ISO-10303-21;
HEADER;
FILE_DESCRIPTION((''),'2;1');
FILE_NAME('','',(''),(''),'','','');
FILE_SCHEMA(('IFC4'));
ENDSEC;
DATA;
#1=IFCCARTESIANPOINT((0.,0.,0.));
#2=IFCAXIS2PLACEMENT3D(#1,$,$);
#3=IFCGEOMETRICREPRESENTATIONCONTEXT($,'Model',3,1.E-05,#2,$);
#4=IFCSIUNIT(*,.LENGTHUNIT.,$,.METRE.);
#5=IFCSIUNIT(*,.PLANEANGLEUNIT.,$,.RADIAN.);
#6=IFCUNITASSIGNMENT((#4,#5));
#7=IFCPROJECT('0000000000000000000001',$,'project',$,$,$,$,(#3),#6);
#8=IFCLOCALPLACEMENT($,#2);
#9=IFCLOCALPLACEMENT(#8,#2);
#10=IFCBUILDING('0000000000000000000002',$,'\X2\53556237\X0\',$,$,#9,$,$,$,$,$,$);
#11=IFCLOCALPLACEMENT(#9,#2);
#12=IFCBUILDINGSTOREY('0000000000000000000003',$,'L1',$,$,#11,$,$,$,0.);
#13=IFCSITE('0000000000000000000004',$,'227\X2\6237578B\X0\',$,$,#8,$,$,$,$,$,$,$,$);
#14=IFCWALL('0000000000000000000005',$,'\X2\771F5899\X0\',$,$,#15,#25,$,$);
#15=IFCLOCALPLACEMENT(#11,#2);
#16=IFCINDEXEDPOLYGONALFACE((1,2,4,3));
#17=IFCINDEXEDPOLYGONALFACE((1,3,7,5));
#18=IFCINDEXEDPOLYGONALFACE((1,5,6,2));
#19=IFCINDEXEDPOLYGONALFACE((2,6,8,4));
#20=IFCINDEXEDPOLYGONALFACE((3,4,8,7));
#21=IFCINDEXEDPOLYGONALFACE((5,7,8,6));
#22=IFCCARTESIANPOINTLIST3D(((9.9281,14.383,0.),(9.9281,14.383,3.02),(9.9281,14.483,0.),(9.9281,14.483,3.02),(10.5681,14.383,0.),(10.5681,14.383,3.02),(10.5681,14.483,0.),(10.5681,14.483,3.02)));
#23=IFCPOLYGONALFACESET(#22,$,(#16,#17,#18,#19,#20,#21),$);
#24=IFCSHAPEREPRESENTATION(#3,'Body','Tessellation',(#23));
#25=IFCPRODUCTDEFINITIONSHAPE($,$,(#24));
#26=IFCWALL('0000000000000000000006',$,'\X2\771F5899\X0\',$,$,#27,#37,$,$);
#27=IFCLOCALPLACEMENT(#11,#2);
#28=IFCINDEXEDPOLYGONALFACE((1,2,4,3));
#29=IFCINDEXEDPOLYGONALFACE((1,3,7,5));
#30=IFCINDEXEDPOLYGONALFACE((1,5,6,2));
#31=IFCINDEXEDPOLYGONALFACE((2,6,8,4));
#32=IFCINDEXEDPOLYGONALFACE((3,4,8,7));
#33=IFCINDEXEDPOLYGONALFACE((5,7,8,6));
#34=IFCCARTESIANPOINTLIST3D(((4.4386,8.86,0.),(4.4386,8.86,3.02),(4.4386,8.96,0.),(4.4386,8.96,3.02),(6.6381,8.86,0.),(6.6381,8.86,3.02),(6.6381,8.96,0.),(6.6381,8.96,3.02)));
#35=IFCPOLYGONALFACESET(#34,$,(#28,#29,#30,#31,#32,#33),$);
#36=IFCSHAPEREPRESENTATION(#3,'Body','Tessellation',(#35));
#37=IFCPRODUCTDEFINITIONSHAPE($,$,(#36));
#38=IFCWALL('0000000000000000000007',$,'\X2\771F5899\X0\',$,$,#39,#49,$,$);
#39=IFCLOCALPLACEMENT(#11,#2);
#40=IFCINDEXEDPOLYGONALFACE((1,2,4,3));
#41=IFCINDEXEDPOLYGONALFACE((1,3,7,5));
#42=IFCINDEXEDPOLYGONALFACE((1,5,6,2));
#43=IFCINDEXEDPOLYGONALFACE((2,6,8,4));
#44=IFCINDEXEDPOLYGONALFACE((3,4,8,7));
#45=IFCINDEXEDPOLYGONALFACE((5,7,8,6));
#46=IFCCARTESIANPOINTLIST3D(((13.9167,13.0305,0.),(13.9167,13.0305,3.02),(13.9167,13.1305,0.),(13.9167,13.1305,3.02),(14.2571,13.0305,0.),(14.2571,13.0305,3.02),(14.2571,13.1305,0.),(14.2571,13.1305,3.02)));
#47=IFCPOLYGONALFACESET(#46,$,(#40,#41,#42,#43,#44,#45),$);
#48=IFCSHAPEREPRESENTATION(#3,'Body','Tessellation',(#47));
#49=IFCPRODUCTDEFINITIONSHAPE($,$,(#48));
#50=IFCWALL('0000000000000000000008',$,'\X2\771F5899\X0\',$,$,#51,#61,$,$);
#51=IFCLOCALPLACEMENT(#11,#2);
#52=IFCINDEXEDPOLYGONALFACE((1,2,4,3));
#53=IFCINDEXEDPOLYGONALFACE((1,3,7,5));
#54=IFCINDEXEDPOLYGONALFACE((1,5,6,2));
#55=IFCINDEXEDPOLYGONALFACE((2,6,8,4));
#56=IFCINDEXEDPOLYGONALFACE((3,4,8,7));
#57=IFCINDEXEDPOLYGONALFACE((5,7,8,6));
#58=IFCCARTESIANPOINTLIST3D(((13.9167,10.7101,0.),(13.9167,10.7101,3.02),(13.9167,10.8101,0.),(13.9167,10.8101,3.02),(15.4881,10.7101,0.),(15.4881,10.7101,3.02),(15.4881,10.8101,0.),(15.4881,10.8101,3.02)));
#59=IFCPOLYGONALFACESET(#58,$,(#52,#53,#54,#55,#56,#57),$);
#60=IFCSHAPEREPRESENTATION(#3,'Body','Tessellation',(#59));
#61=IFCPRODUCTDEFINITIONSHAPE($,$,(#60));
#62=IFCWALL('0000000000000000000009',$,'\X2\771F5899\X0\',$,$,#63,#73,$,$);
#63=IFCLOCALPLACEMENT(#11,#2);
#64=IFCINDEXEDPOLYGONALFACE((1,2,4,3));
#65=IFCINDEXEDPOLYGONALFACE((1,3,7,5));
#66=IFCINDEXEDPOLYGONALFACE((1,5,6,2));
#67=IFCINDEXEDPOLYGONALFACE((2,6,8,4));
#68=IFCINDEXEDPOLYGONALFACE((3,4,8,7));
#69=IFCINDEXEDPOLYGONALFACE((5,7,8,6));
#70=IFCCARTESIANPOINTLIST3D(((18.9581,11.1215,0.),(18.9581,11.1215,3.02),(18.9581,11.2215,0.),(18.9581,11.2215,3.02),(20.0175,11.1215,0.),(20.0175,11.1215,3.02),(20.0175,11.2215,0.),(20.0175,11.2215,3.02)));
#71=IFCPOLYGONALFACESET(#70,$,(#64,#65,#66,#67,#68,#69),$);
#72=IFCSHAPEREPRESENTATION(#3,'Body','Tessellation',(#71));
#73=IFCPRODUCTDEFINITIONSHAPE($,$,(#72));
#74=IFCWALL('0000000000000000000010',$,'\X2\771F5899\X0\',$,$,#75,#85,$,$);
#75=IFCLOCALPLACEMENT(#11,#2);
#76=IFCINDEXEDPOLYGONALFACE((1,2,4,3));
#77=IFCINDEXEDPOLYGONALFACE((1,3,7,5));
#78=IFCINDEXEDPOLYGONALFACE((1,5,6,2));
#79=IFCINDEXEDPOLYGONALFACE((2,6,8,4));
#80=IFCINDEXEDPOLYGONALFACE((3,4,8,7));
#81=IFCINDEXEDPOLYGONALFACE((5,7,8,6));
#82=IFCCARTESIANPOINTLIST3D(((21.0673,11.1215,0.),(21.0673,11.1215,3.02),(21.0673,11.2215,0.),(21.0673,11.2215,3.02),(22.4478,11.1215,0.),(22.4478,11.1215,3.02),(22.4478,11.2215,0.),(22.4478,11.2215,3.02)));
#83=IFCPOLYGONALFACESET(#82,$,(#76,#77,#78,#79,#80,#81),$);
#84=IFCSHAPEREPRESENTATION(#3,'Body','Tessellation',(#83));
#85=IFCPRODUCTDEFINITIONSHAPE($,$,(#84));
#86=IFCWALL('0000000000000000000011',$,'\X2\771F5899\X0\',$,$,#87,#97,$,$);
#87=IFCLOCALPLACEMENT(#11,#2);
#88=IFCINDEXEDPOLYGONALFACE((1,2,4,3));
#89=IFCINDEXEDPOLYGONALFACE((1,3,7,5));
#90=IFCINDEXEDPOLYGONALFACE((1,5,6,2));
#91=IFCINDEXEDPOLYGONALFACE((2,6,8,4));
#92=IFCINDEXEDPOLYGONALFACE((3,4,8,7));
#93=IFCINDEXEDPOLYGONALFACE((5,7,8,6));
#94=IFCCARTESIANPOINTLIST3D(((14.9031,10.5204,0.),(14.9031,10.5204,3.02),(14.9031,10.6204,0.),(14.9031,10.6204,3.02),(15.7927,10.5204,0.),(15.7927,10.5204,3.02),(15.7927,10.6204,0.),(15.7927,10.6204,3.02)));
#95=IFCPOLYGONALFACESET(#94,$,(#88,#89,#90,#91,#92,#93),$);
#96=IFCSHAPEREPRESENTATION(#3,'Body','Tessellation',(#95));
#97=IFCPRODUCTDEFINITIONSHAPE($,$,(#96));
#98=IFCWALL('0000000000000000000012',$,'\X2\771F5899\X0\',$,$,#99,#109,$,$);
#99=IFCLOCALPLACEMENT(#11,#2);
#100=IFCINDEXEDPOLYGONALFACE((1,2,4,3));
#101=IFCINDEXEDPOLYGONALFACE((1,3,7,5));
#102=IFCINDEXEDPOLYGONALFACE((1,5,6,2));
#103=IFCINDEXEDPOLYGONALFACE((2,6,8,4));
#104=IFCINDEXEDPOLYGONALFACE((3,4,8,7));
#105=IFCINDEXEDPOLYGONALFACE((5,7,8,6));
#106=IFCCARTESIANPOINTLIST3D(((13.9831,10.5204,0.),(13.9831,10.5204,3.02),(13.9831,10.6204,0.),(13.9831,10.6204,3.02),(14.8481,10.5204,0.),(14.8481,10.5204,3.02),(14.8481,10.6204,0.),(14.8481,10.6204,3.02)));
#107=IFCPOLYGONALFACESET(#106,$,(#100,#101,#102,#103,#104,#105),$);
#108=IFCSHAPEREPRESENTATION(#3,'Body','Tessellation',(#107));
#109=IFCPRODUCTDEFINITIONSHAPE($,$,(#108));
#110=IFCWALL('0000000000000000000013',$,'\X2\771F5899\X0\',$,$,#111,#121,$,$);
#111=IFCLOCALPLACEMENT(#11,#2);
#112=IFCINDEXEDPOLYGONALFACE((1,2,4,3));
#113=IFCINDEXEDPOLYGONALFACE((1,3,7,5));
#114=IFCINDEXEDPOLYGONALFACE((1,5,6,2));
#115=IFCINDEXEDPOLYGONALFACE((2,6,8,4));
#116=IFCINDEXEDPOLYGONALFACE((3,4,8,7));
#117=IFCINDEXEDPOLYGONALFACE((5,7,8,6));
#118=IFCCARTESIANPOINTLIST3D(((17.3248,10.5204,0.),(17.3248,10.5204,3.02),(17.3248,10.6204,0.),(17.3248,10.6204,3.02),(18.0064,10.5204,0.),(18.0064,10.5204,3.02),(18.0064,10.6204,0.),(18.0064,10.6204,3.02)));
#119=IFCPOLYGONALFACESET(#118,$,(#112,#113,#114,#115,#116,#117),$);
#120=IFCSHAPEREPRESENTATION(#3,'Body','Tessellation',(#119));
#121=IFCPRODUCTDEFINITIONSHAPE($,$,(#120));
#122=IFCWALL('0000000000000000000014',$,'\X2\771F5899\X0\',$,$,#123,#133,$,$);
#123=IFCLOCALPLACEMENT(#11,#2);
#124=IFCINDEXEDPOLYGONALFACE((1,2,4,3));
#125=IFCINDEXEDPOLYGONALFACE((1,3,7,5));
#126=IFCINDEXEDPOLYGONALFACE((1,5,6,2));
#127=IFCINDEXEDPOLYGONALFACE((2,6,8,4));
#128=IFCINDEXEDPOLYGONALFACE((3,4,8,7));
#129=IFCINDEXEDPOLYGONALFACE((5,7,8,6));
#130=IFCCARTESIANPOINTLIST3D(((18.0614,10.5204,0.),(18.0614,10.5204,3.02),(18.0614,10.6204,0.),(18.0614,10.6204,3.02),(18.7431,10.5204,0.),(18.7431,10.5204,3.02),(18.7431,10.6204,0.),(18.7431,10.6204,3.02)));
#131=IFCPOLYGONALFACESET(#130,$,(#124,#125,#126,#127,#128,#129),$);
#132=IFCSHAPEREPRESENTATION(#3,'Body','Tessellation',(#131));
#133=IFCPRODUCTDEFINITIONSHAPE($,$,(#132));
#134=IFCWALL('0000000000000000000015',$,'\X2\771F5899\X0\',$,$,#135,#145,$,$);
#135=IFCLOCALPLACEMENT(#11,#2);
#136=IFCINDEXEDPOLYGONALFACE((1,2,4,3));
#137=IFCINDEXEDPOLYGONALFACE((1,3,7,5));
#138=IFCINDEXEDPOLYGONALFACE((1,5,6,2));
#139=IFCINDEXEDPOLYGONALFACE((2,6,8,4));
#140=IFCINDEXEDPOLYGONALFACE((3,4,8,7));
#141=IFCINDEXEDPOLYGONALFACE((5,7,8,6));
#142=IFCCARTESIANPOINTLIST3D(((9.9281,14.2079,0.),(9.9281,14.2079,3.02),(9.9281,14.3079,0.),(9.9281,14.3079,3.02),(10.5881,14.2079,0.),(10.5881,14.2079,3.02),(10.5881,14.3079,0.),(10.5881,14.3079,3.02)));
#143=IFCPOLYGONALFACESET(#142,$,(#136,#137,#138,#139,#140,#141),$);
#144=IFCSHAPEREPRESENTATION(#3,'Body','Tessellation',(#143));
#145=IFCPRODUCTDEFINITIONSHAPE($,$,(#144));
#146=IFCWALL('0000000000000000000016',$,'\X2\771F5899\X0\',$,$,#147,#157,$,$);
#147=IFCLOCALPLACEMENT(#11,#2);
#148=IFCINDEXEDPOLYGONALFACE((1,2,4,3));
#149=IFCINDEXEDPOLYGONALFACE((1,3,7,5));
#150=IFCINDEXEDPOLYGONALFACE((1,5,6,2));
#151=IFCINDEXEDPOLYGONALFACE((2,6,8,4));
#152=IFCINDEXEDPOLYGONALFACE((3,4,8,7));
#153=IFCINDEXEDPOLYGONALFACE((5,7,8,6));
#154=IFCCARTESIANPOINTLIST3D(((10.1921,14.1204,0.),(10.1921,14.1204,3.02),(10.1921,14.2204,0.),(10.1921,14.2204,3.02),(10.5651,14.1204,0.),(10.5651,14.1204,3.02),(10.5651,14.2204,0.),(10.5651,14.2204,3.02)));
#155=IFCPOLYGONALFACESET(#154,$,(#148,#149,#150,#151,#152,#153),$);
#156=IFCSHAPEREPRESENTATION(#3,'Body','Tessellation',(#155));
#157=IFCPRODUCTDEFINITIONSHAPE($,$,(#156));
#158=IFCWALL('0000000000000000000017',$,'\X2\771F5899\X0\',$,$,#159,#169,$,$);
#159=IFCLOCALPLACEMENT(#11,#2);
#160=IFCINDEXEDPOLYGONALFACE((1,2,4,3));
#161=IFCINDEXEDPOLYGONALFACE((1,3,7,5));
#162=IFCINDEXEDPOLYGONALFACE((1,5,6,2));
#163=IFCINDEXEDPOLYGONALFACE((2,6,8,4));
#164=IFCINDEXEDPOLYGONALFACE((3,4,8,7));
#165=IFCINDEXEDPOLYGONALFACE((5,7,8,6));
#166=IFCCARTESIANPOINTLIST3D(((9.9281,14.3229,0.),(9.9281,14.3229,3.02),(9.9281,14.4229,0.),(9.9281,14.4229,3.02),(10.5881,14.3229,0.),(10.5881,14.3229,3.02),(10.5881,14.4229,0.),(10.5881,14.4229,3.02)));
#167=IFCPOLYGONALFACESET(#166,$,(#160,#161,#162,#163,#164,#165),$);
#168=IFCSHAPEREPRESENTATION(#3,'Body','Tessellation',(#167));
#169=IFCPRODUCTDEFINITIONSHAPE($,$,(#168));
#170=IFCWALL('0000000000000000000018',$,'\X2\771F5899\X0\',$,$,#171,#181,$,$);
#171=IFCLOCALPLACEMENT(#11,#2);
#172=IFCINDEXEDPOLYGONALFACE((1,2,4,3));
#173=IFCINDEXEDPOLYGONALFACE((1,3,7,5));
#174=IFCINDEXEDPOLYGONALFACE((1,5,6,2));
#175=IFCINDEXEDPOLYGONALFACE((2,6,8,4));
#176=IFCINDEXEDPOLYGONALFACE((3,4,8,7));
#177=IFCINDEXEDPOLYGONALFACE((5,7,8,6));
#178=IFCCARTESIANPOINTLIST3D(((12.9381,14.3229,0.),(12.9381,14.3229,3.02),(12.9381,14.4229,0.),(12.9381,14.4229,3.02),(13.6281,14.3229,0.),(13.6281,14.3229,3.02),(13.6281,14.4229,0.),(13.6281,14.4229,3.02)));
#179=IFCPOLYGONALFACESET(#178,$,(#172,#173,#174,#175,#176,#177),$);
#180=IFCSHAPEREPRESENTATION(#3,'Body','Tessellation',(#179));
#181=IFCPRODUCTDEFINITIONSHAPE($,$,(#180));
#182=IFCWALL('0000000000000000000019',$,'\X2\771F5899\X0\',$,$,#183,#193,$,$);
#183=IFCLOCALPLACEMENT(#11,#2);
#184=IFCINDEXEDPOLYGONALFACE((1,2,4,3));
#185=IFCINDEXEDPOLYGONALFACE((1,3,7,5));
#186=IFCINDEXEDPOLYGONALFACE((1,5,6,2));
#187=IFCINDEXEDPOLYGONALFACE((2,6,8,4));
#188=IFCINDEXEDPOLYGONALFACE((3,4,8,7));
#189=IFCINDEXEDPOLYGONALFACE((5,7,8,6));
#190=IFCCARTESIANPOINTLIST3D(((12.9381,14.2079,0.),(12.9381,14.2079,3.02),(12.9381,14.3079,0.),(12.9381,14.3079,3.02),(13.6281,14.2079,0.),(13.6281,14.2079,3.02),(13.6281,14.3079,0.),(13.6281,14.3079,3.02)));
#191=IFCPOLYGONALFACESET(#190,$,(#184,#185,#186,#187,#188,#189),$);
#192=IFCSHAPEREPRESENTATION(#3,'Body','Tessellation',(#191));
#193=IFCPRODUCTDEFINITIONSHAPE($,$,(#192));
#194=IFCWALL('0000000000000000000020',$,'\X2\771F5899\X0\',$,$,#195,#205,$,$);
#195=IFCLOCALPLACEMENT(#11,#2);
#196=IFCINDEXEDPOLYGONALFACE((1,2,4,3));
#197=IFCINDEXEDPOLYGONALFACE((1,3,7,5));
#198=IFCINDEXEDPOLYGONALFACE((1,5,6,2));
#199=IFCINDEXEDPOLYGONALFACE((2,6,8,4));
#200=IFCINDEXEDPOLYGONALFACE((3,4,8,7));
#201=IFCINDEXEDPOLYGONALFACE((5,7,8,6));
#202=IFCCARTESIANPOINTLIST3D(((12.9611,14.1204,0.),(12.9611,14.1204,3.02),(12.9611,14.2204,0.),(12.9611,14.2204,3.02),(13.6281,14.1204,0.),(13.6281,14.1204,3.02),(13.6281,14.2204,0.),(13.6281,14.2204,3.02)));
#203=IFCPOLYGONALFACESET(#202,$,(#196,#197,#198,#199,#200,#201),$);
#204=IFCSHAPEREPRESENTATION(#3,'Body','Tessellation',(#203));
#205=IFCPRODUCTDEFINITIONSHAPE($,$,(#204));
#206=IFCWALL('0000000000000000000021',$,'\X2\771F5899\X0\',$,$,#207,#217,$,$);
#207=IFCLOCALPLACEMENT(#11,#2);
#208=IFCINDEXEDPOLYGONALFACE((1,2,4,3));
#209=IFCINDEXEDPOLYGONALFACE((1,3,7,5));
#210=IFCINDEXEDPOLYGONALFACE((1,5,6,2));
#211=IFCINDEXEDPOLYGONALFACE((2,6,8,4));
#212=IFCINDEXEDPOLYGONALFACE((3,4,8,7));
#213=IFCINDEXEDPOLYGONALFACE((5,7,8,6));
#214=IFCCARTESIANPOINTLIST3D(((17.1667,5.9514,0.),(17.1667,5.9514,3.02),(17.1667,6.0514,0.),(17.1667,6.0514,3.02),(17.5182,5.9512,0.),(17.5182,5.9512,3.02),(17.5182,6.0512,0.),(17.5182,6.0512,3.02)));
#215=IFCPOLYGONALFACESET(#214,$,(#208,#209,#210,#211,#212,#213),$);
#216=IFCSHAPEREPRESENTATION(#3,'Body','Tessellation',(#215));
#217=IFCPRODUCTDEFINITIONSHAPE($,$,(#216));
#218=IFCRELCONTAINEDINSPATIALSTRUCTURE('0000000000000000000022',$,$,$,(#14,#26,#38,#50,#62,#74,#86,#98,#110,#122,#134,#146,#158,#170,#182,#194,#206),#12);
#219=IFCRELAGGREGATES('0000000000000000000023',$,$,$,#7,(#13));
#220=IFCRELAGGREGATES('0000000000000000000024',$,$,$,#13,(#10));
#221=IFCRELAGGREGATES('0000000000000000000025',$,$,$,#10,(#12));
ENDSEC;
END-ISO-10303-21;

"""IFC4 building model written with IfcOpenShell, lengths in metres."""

from ifc_helpers import new_model, si_unit, origin, place, context, project, spatial, polyline, outline, extrude, element, save


model = new_model("IFC4")

# Units and contexts
model_context = context("Model", 3, precision=1e-05, world=origin())
ifc_project = project(units=[si_unit("LENGTHUNIT", "METRE"), si_unit("PLANEANGLEUNIT", "RADIAN")], contexts=[model_context])

# Site, building, storey
site_placement = place(None, origin())
site = spatial("IfcSite", under=ifc_project, at=site_placement, Name="227户型")
building_placement = place(site_placement, origin())
building = spatial("IfcBuilding", under=site, at=building_placement, Name="单户")
storey_placement = place(building_placement, origin())
storey = spatial("IfcBuildingStorey", under=building, at=storey_placement, Name="L1", Elevation=0.0)

# Walls
wall_1_placement = place(storey_placement, origin())
element("IfcWall", 1, at=wall_1_placement, inside=storey, Name="真墙", context=model_context, shape_type="SweptSolid", body=[
    extrude(outline(polyline([(10.5681, 14.383), (9.9281, 14.383), (9.9281, 14.483), (10.5681, 14.483), (10.5681, 14.383)])), origin(), (0.0, 0.0, 1.0), 3.02),
])
wall_2_placement = place(storey_placement, origin())
element("IfcWall", 2, at=wall_2_placement, inside=storey, Name="真墙", context=model_context, shape_type="SweptSolid", body=[
    extrude(outline(polyline([(6.6381, 8.86), (4.4386, 8.86), (4.4386, 8.96), (6.6381, 8.96), (6.6381, 8.86)])), origin(), (0.0, 0.0, 1.0), 3.02),
])
wall_3_placement = place(storey_placement, origin())
element("IfcWall", 3, at=wall_3_placement, inside=storey, Name="真墙", context=model_context, shape_type="SweptSolid", body=[
    extrude(outline(polyline([(14.2571, 13.0305), (13.9167, 13.0305), (13.9167, 13.1305), (14.2571, 13.1305), (14.2571, 13.0305)])), origin(), (0.0, 0.0, 1.0), 3.02),
])
wall_4_placement = place(storey_placement, origin())
element("IfcWall", 4, at=wall_4_placement, inside=storey, Name="真墙", context=model_context, shape_type="SweptSolid", body=[
    extrude(outline(polyline([(13.9167, 10.8101), (15.4881, 10.8101), (15.4881, 10.7101), (13.9167, 10.7101), (13.9167, 10.8101)])), origin(), (0.0, 0.0, 1.0), 3.02),
])
wall_5_placement = place(storey_placement, origin())
element("IfcWall", 5, at=wall_5_placement, inside=storey, Name="真墙", context=model_context, shape_type="SweptSolid", body=[
    extrude(outline(polyline([(20.0175, 11.1215), (18.9581, 11.1215), (18.9581, 11.2215), (20.0175, 11.2215), (20.0175, 11.1215)])), origin(), (0.0, 0.0, 1.0), 3.02),
])
wall_6_placement = place(storey_placement, origin())
element("IfcWall", 6, at=wall_6_placement, inside=storey, Name="真墙", context=model_context, shape_type="SweptSolid", body=[
    extrude(outline(polyline([(21.0673, 11.2215), (22.4478, 11.2215), (22.4478, 11.1215), (21.0673, 11.1215), (21.0673, 11.2215)])), origin(), (0.0, 0.0, 1.0), 3.02),
])

# Walls
wall_7_placement = place(storey_placement, origin())
element("IfcWall", 7, at=wall_7_placement, inside=storey, Name="真墙", context=model_context, shape_type="SweptSolid", body=[
    extrude(outline(polyline([(14.9031, 10.6204), (15.7927, 10.6204), (15.7927, 10.5204), (14.9031, 10.5204), (14.9031, 10.6204)])), origin(), (0.0, 0.0, 1.0), 3.02),
])
wall_8_placement = place(storey_placement, origin())
element("IfcWall", 8, at=wall_8_placement, inside=storey, Name="真墙", context=model_context, shape_type="SweptSolid", body=[
    extrude(outline(polyline([(13.9831, 10.6204), (14.8481, 10.6204), (14.8481, 10.5204), (13.9831, 10.5204), (13.9831, 10.6204)])), origin(), (0.0, 0.0, 1.0), 3.02),
])
wall_9_placement = place(storey_placement, origin())
element("IfcWall", 9, at=wall_9_placement, inside=storey, Name="真墙", context=model_context, shape_type="SweptSolid", body=[
    extrude(outline(polyline([(18.0064, 10.5204), (17.3248, 10.5204), (17.3248, 10.6204), (18.0064, 10.6204), (18.0064, 10.5204)])), origin(), (0.0, 0.0, 1.0), 3.02),
])
wall_10_placement = place(storey_placement, origin())
element("IfcWall", 10, at=wall_10_placement, inside=storey, Name="真墙", context=model_context, shape_type="SweptSolid", body=[
    extrude(outline(polyline([(18.7431, 10.5204), (18.0614, 10.5204), (18.0614, 10.6204), (18.7431, 10.6204), (18.7431, 10.5204)])), origin(), (0.0, 0.0, 1.0), 3.02),
])
wall_11_placement = place(storey_placement, origin())
element("IfcWall", 11, at=wall_11_placement, inside=storey, Name="真墙", context=model_context, shape_type="SweptSolid", body=[
    extrude(outline(polyline([(10.5881, 14.2079), (9.9281, 14.2079), (9.9281, 14.3079), (10.5881, 14.3079), (10.5881, 14.2079)])), origin(), (0.0, 0.0, 1.0), 3.02),
])
wall_12_placement = place(storey_placement, origin())
element("IfcWall", 12, at=wall_12_placement, inside=storey, Name="真墙", context=model_context, shape_type="SweptSolid", body=[
    extrude(outline(polyline([(10.5651, 14.1204), (10.1921, 14.1204), (10.1921, 14.2204), (10.5651, 14.2204), (10.5651, 14.1204)])), origin(), (0.0, 0.0, 1.0), 3.02),
])
wall_13_placement = place(storey_placement, origin())
element("IfcWall", 13, at=wall_13_placement, inside=storey, Name="真墙", context=model_context, shape_type="SweptSolid", body=[
    extrude(outline(polyline([(10.5881, 14.3229), (9.9281, 14.3229), (9.9281, 14.4229), (10.5881, 14.4229), (10.5881, 14.3229)])), origin(), (0.0, 0.0, 1.0), 3.02),
])

# Walls
wall_14_placement = place(storey_placement, origin())
element("IfcWall", 14, at=wall_14_placement, inside=storey, Name="真墙", context=model_context, shape_type="SweptSolid", body=[
    extrude(outline(polyline([(12.9381, 14.4229), (13.6281, 14.4229), (13.6281, 14.3229), (12.9381, 14.3229), (12.9381, 14.4229)])), origin(), (0.0, 0.0, 1.0), 3.02),
])
wall_15_placement = place(storey_placement, origin())
element("IfcWall", 15, at=wall_15_placement, inside=storey, Name="真墙", context=model_context, shape_type="SweptSolid", body=[
    extrude(outline(polyline([(12.9381, 14.3079), (13.6281, 14.3079), (13.6281, 14.2079), (12.9381, 14.2079), (12.9381, 14.3079)])), origin(), (0.0, 0.0, 1.0), 3.02),
])
wall_16_placement = place(storey_placement, origin())
element("IfcWall", 16, at=wall_16_placement, inside=storey, Name="真墙", context=model_context, shape_type="SweptSolid", body=[
    extrude(outline(polyline([(12.9611, 14.2204), (13.6281, 14.2204), (13.6281, 14.1204), (12.9611, 14.1204), (12.9611, 14.2204)])), origin(), (0.0, 0.0, 1.0), 3.02),
])

# Wall
wall_17_placement = place(storey_placement, origin())
element("IfcWall", 17, at=wall_17_placement, inside=storey, Name="真墙", context=model_context, shape_type="SweptSolid", body=[
    extrude(outline(polyline([(17.5182, 5.9512), (17.1667, 5.9514), (17.1667, 6.0514), (17.5182, 6.0512), (17.5182, 5.9512)])), origin(), (0.0, 0.0, 1.0), 3.02),
])

save(model, "model.ifc")
